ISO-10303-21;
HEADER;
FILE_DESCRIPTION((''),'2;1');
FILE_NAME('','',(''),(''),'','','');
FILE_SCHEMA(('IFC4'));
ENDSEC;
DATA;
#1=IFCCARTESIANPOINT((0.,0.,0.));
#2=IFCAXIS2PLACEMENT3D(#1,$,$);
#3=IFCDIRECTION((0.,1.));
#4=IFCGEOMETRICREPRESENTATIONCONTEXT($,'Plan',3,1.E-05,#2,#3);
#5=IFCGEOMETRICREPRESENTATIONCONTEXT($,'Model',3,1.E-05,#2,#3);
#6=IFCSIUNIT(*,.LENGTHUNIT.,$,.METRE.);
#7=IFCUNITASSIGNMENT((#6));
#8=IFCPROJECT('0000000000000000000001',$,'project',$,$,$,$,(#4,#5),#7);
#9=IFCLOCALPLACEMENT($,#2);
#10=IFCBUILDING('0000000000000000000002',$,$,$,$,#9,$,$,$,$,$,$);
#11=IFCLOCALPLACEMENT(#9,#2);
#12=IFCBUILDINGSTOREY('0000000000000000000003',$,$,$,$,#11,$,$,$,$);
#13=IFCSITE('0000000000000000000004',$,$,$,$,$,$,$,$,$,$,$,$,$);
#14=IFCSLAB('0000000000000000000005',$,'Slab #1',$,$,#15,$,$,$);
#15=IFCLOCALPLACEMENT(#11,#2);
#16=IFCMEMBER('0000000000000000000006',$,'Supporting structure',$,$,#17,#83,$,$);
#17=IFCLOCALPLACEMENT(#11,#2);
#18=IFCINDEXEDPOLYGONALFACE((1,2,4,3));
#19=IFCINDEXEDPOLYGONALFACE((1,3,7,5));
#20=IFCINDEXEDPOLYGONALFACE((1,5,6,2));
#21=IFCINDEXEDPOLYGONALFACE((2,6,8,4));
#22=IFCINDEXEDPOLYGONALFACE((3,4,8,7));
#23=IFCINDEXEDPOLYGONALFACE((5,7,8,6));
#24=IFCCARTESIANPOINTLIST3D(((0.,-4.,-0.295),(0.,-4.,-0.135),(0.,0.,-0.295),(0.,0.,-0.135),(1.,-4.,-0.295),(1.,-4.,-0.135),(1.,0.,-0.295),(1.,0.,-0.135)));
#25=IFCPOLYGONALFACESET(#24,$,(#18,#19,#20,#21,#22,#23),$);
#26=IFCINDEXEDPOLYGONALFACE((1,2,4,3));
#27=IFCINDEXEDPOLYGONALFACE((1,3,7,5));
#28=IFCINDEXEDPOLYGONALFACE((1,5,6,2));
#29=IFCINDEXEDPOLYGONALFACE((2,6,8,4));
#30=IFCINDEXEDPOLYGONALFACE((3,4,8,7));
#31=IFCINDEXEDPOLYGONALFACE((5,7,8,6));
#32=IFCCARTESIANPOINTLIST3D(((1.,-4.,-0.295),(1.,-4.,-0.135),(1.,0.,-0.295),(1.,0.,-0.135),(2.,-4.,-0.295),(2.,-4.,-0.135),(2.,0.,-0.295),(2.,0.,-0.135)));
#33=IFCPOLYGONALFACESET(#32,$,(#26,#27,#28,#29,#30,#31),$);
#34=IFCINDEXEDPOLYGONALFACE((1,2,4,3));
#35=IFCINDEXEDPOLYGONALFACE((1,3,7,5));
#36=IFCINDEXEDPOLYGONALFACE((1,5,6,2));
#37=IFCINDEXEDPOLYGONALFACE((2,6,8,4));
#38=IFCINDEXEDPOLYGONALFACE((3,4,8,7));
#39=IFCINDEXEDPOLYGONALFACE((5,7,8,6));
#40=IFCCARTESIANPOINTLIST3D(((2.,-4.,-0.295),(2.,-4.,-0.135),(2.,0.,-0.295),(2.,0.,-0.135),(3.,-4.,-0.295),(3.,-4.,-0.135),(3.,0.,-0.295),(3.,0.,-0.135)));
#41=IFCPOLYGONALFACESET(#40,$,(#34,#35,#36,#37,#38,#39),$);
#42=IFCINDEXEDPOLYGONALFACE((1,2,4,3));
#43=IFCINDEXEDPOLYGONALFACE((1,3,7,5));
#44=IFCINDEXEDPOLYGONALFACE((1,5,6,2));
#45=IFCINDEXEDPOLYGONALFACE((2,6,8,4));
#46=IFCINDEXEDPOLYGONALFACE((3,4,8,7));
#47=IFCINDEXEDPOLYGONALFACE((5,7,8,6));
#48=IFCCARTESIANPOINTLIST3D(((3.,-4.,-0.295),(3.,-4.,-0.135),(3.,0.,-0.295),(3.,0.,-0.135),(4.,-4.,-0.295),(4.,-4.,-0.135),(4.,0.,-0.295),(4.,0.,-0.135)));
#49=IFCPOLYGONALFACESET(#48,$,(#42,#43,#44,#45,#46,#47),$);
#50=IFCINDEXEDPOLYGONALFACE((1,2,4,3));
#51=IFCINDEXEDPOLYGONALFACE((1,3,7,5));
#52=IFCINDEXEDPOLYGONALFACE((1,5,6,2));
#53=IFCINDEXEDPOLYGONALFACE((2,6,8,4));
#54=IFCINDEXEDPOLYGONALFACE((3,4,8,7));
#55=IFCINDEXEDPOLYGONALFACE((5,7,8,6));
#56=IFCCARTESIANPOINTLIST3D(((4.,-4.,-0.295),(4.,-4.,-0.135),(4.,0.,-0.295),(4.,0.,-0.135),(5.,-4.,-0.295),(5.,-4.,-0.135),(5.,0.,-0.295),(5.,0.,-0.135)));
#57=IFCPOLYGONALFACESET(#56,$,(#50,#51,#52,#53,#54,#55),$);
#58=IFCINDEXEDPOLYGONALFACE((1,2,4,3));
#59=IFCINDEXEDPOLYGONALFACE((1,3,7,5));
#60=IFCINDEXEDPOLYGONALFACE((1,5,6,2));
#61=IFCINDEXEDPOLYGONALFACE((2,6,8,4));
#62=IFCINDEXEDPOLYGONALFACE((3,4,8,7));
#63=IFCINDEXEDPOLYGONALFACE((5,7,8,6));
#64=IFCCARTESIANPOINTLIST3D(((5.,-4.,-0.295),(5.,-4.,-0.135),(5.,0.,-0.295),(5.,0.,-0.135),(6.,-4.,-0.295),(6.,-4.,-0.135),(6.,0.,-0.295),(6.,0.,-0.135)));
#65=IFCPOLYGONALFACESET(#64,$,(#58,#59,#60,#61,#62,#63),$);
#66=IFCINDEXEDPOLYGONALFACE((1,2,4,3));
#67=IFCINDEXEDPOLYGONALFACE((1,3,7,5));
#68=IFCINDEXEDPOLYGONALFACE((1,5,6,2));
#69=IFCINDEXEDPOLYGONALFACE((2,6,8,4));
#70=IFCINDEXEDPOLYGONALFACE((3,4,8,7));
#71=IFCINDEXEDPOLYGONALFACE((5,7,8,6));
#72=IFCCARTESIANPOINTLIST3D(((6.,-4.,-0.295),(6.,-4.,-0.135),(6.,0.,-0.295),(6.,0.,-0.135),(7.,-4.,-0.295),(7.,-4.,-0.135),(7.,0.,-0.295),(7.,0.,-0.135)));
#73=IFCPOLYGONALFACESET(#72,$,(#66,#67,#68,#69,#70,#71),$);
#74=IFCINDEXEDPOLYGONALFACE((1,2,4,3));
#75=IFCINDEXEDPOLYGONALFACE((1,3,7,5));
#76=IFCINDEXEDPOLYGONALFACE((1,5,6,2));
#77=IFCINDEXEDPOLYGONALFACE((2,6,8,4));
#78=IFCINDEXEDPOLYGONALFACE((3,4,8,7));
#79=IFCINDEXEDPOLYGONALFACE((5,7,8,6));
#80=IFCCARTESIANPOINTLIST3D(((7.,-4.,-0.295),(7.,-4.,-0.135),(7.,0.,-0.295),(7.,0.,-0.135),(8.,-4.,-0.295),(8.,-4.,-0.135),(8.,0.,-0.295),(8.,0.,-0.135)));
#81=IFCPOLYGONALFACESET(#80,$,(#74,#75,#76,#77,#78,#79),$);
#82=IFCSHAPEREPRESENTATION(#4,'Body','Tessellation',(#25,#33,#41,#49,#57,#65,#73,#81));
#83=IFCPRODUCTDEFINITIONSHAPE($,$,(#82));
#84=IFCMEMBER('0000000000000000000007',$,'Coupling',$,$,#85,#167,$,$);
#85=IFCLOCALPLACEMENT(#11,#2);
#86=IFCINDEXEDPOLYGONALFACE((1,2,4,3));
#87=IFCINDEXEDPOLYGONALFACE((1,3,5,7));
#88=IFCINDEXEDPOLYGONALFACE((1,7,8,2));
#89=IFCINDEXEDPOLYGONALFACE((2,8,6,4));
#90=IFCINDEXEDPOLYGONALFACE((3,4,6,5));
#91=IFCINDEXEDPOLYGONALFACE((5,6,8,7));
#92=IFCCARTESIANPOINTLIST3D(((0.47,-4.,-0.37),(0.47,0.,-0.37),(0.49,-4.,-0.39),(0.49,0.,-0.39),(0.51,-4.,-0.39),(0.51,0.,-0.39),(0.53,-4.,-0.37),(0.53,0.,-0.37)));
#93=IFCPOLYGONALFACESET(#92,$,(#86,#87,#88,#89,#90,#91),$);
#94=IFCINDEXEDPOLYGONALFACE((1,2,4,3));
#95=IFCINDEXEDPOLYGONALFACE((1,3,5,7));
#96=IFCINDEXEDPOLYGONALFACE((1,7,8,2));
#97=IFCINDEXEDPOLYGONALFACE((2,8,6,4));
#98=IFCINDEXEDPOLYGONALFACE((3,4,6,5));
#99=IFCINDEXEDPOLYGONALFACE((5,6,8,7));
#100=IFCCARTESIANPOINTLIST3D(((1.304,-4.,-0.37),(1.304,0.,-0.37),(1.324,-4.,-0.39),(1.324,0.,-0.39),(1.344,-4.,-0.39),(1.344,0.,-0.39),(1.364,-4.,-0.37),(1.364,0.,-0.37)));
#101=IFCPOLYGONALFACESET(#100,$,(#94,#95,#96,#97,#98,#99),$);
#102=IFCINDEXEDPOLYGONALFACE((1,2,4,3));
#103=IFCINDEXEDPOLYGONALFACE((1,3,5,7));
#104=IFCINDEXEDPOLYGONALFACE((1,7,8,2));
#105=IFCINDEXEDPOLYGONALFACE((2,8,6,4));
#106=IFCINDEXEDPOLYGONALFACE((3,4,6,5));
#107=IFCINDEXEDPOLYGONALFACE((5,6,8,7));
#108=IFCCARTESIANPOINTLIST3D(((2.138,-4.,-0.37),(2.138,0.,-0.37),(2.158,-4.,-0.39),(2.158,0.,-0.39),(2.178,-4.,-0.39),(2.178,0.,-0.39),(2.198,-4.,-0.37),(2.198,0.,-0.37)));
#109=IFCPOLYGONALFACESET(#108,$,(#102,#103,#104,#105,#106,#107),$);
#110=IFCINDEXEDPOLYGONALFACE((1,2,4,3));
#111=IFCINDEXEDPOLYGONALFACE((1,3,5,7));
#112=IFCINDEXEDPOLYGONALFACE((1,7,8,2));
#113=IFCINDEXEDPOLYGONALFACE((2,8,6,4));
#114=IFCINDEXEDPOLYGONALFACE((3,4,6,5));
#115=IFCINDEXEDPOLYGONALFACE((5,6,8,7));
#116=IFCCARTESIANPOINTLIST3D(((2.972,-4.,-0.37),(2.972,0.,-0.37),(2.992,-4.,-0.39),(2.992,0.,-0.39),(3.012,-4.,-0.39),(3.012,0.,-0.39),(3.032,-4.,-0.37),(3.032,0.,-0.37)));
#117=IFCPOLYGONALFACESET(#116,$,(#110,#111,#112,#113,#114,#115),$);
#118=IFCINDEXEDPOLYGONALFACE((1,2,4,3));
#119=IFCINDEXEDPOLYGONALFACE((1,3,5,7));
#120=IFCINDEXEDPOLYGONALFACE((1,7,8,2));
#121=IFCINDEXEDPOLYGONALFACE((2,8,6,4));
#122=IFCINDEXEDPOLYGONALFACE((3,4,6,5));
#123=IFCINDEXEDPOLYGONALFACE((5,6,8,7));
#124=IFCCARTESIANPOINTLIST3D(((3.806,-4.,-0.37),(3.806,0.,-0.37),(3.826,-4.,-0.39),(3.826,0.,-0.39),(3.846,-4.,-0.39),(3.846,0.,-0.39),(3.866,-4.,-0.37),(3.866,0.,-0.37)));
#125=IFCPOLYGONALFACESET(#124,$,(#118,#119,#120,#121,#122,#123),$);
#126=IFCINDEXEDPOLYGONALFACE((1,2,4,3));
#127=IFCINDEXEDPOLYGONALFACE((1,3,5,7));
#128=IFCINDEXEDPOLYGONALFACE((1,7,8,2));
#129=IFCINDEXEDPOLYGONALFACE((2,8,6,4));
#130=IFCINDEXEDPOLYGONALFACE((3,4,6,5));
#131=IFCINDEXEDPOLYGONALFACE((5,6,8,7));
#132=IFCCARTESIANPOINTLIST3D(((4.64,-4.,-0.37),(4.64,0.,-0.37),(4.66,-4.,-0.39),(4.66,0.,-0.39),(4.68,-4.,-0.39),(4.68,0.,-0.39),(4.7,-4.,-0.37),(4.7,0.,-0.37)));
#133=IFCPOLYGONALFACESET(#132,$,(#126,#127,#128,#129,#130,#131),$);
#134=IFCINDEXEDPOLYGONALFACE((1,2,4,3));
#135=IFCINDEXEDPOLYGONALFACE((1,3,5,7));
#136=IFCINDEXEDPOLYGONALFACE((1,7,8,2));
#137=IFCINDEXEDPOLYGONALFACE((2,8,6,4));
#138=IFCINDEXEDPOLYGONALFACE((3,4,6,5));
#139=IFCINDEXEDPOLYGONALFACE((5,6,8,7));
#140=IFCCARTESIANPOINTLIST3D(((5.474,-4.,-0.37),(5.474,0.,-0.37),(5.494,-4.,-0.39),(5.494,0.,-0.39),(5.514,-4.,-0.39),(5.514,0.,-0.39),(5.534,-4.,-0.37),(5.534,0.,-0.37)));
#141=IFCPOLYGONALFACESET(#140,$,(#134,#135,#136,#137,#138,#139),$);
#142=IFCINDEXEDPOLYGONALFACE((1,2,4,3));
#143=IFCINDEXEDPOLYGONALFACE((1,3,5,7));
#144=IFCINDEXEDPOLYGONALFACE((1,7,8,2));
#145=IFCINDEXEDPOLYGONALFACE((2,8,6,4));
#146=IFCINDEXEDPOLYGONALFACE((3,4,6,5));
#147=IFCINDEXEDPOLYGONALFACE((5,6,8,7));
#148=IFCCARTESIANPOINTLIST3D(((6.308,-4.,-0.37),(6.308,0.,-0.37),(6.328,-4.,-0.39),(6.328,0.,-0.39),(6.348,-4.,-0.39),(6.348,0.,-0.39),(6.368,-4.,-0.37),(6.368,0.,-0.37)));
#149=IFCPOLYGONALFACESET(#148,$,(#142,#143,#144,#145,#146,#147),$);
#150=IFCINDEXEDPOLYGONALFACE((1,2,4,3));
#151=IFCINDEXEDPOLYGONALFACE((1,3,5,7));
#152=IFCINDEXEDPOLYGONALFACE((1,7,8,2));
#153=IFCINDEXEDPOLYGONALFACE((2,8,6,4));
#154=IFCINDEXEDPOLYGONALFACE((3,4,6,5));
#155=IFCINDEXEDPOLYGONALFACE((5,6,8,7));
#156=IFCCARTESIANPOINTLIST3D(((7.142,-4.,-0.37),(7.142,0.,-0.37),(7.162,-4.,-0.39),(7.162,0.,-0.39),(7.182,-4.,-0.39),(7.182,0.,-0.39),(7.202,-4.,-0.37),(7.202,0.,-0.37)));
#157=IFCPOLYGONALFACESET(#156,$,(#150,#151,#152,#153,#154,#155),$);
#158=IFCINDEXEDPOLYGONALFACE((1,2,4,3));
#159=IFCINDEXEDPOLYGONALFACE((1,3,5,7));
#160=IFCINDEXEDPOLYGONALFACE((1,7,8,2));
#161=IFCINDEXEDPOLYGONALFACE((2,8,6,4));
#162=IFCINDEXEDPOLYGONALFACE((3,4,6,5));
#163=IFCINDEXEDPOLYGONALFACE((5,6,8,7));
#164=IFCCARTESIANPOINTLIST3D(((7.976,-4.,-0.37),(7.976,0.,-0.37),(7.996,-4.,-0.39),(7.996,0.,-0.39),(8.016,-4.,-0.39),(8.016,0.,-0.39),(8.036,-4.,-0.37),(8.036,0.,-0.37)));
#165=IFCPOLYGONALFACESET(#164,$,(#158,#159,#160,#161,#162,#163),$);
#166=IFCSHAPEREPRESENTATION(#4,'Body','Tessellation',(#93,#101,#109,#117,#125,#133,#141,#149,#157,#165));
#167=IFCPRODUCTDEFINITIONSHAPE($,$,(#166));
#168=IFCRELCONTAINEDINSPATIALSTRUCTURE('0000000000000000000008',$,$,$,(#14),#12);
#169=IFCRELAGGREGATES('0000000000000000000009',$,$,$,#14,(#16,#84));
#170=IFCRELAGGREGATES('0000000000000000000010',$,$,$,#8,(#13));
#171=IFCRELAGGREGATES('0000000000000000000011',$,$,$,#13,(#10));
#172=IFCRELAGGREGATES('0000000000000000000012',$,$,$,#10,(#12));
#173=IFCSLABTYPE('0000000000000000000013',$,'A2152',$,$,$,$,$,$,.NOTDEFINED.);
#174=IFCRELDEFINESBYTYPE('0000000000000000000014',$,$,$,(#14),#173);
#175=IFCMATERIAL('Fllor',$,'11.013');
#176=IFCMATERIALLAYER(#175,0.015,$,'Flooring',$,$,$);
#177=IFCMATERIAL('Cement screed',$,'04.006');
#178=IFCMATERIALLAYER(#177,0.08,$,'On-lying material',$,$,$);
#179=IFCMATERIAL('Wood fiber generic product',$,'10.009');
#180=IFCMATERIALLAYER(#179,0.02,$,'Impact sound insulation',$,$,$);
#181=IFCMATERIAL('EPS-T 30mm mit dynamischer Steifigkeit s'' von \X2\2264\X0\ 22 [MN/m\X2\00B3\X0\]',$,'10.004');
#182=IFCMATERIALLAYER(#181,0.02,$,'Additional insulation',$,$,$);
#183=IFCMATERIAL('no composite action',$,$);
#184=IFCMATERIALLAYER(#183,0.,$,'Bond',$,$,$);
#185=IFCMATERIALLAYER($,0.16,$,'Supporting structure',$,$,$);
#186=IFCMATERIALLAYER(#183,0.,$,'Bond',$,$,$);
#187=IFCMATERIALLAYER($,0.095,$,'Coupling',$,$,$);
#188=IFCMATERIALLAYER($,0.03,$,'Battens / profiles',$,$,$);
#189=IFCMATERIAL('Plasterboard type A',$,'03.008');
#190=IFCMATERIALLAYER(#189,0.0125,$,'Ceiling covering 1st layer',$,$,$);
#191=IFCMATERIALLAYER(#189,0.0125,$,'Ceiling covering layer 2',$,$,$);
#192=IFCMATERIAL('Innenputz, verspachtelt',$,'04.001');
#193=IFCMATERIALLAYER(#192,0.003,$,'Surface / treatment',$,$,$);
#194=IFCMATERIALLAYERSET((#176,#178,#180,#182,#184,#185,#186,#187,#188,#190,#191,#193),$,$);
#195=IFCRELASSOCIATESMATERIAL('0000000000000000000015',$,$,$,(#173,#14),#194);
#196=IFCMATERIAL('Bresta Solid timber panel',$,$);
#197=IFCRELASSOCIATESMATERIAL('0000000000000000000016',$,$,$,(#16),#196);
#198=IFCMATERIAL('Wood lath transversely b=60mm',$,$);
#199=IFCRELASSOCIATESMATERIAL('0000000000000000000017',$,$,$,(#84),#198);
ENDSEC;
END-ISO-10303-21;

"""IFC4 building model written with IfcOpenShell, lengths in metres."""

from ifc_helpers import new_model, si_unit, direction, frame, frame_2d, origin, place, context, project, spatial, polyline, rectangle, outline, extrude, material, layer, layer_set, type_object, element, aggregate, save


model = new_model("IFC4")

# Units and contexts
plan_context = context("Plan", 3, precision=1e-05, world=origin(), true_north=direction((0.0, 1.0)))
model_context = context("Model", 3, precision=1e-05, world=origin(), true_north=direction((0.0, 1.0)))
ifc_project = project(units=[si_unit("LENGTHUNIT", "METRE")], contexts=[plan_context, model_context])

# Site, building, storey
site = spatial("IfcSite", under=ifc_project)
building_placement = place(None, origin())
building = spatial("IfcBuilding", under=site, at=building_placement)
storey_placement = place(building_placement, origin())
storey = spatial("IfcBuildingStorey", under=building, at=storey_placement)

# Slab, members
ifc_material_1 = material(Name="Fllor", Category="11.013")
ifc_layer_1 = layer(ifc_material_1, 0.015, Name="Flooring")
ifc_material_2 = material(Name="Cement screed", Category="04.006")
ifc_layer_2 = layer(ifc_material_2, 0.08, Name="On-lying material")
ifc_material_3 = material(Name="Wood fiber generic product", Category="10.009")
ifc_layer_3 = layer(ifc_material_3, 0.02, Name="Impact sound insulation")
ifc_material_4 = material(Name="EPS-T 30mm mit dynamischer Steifigkeit s' von ≤ 22 [MN/m³]", Category="10.004")
ifc_layer_4 = layer(ifc_material_4, 0.02, Name="Additional insulation")
ifc_material_5 = material(Name="no composite action")
ifc_layer_5 = layer(ifc_material_5, 0.0, Name="Bond")
ifc_layer_6 = layer(None, 0.16, Name="Supporting structure")
ifc_layer_7 = layer(ifc_material_5, 0.0, Name="Bond")
ifc_layer_8 = layer(None, 0.095, Name="Coupling")
ifc_layer_9 = layer(None, 0.03, Name="Battens / profiles")
ifc_material_6 = material(Name="Plasterboard type A", Category="03.008")
ifc_layer_10 = layer(ifc_material_6, 0.0125, Name="Ceiling covering 1st layer")
ifc_layer_11 = layer(ifc_material_6, 0.0125, Name="Ceiling covering layer 2")
ifc_material_7 = material(Name="Innenputz, verspachtelt", Category="04.001")
ifc_layer_12 = layer(ifc_material_7, 0.003, Name="Surface / treatment")
ifc_layer_set = layer_set([ifc_layer_1, ifc_layer_2, ifc_layer_3, ifc_layer_4, ifc_layer_5, ifc_layer_6, ifc_layer_7, ifc_layer_8, ifc_layer_9, ifc_layer_10, ifc_layer_11, ifc_layer_12])
slab_type = type_object("IfcSlabType", Name="A2152", PredefinedType="NOTDEFINED", material=ifc_layer_set)
slab_placement = place(None, frame((0.0, 0.0, 0.0), z_axis=(0.0, 0.0, -1.0), x_axis=(1.0, 0.0, 0.0)))
slab = element("IfcSlab", 1, at=slab_placement, inside=storey, type_object=slab_type, material=ifc_layer_set, Name="Slab #1")
ifc_material_8 = material(Name="Bresta Solid timber panel")
member_1_placement = place(slab_placement, origin())
member_1 = element("IfcMember", 2, at=member_1_placement, material=ifc_material_8, Name="Supporting structure", context=plan_context, shape_type="SweptSolid", body=[
    extrude(rectangle(XDim=1.0, YDim=0.16, at=frame_2d((0.5, 0.08), x_axis=(1.0, 0.0))), frame((0.0, 4.0, 0.135), z_axis=(0.0, -1.0, 0.0), x_axis=(1.0, 0.0, 0.0)), (0.0, 0.0, 1.0), 4.0),
    extrude(rectangle(XDim=1.0, YDim=0.16, at=frame_2d((0.5, 0.08), x_axis=(1.0, 0.0))), frame((1.0, 4.0, 0.135), z_axis=(0.0, -1.0, 0.0), x_axis=(1.0, 0.0, 0.0)), (0.0, 0.0, 1.0), 4.0),
    extrude(rectangle(XDim=1.0, YDim=0.16, at=frame_2d((0.5, 0.08), x_axis=(1.0, 0.0))), frame((2.0, 4.0, 0.135), z_axis=(0.0, -1.0, 0.0), x_axis=(1.0, 0.0, 0.0)), (0.0, 0.0, 1.0), 4.0),
    extrude(rectangle(XDim=1.0, YDim=0.16, at=frame_2d((0.5, 0.08), x_axis=(1.0, 0.0))), frame((3.0, 4.0, 0.135), z_axis=(0.0, -1.0, 0.0), x_axis=(1.0, 0.0, 0.0)), (0.0, 0.0, 1.0), 4.0),
    extrude(rectangle(XDim=1.0, YDim=0.16, at=frame_2d((0.5, 0.08), x_axis=(1.0, 0.0))), frame((4.0, 4.0, 0.135), z_axis=(0.0, -1.0, 0.0), x_axis=(1.0, 0.0, 0.0)), (0.0, 0.0, 1.0), 4.0),
    extrude(rectangle(XDim=1.0, YDim=0.16, at=frame_2d((0.5, 0.08), x_axis=(1.0, 0.0))), frame((5.0, 4.0, 0.135), z_axis=(0.0, -1.0, 0.0), x_axis=(1.0, 0.0, 0.0)), (0.0, 0.0, 1.0), 4.0),
    extrude(rectangle(XDim=1.0, YDim=0.16, at=frame_2d((0.5, 0.08), x_axis=(1.0, 0.0))), frame((6.0, 4.0, 0.135), z_axis=(0.0, -1.0, 0.0), x_axis=(1.0, 0.0, 0.0)), (0.0, 0.0, 1.0), 4.0),
    extrude(rectangle(XDim=1.0, YDim=0.16, at=frame_2d((0.5, 0.08), x_axis=(1.0, 0.0))), frame((7.0, 4.0, 0.135), z_axis=(0.0, -1.0, 0.0), x_axis=(1.0, 0.0, 0.0)), (0.0, 0.0, 1.0), 4.0),
])
ifc_material_9 = material(Name="Wood lath transversely b=60mm")
member_2_placement = place(slab_placement, origin())
member_2 = element("IfcMember", 3, at=member_2_placement, material=ifc_material_9, Name="Coupling", context=plan_context, shape_type="SweptSolid", body=[
    extrude(outline(polyline([(0.0, 0.0), (0.06, 0.0), (0.04, 0.02), (0.02, 0.02), (0.0, 0.0)])), frame((0.47, 4.0, 0.37), z_axis=(0.0, -1.0, 0.0), x_axis=(1.0, 0.0, 0.0)), (0.0, 0.0, 1.0), 4.0),
    extrude(outline(polyline([(0.0, 0.0), (0.06, 0.0), (0.04, 0.02), (0.02, 0.02), (0.0, 0.0)])), frame((1.304, 4.0, 0.37), z_axis=(0.0, -1.0, 0.0), x_axis=(1.0, 0.0, 0.0)), (0.0, 0.0, 1.0), 4.0),
    extrude(outline(polyline([(0.0, 0.0), (0.06, 0.0), (0.04, 0.02), (0.02, 0.02), (0.0, 0.0)])), frame((2.138, 4.0, 0.37), z_axis=(0.0, -1.0, 0.0), x_axis=(1.0, 0.0, 0.0)), (0.0, 0.0, 1.0), 4.0),
    extrude(outline(polyline([(0.0, 0.0), (0.06, 0.0), (0.04, 0.02), (0.02, 0.02), (0.0, 0.0)])), frame((2.972, 4.0, 0.37), z_axis=(0.0, -1.0, 0.0), x_axis=(1.0, 0.0, 0.0)), (0.0, 0.0, 1.0), 4.0),
    extrude(outline(polyline([(0.0, 0.0), (0.06, 0.0), (0.04, 0.02), (0.02, 0.02), (0.0, 0.0)])), frame((3.806, 4.0, 0.37), z_axis=(0.0, -1.0, 0.0), x_axis=(1.0, 0.0, 0.0)), (0.0, 0.0, 1.0), 4.0),
    extrude(outline(polyline([(0.0, 0.0), (0.06, 0.0), (0.04, 0.02), (0.02, 0.02), (0.0, 0.0)])), frame((4.64, 4.0, 0.37), z_axis=(0.0, -1.0, 0.0), x_axis=(1.0, 0.0, 0.0)), (0.0, 0.0, 1.0), 4.0),
    extrude(outline(polyline([(0.0, 0.0), (0.06, 0.0), (0.04, 0.02), (0.02, 0.02), (0.0, 0.0)])), frame((5.474, 4.0, 0.37), z_axis=(0.0, -1.0, 0.0), x_axis=(1.0, 0.0, 0.0)), (0.0, 0.0, 1.0), 4.0),
    extrude(outline(polyline([(0.0, 0.0), (0.06, 0.0), (0.04, 0.02), (0.02, 0.02), (0.0, 0.0)])), frame((6.308, 4.0, 0.37), z_axis=(0.0, -1.0, 0.0), x_axis=(1.0, 0.0, 0.0)), (0.0, 0.0, 1.0), 4.0),
    extrude(outline(polyline([(0.0, 0.0), (0.06, 0.0), (0.04, 0.02), (0.02, 0.02), (0.0, 0.0)])), frame((7.142, 4.0, 0.37), z_axis=(0.0, -1.0, 0.0), x_axis=(1.0, 0.0, 0.0)), (0.0, 0.0, 1.0), 4.0),
    extrude(outline(polyline([(0.0, 0.0), (0.06, 0.0), (0.04, 0.02), (0.02, 0.02), (0.0, 0.0)])), frame((7.976, 4.0, 0.37), z_axis=(0.0, -1.0, 0.0), x_axis=(1.0, 0.0, 0.0)), (0.0, 0.0, 1.0), 4.0),
])
aggregate(slab, [member_1, member_2])

save(model, "model.ifc")
